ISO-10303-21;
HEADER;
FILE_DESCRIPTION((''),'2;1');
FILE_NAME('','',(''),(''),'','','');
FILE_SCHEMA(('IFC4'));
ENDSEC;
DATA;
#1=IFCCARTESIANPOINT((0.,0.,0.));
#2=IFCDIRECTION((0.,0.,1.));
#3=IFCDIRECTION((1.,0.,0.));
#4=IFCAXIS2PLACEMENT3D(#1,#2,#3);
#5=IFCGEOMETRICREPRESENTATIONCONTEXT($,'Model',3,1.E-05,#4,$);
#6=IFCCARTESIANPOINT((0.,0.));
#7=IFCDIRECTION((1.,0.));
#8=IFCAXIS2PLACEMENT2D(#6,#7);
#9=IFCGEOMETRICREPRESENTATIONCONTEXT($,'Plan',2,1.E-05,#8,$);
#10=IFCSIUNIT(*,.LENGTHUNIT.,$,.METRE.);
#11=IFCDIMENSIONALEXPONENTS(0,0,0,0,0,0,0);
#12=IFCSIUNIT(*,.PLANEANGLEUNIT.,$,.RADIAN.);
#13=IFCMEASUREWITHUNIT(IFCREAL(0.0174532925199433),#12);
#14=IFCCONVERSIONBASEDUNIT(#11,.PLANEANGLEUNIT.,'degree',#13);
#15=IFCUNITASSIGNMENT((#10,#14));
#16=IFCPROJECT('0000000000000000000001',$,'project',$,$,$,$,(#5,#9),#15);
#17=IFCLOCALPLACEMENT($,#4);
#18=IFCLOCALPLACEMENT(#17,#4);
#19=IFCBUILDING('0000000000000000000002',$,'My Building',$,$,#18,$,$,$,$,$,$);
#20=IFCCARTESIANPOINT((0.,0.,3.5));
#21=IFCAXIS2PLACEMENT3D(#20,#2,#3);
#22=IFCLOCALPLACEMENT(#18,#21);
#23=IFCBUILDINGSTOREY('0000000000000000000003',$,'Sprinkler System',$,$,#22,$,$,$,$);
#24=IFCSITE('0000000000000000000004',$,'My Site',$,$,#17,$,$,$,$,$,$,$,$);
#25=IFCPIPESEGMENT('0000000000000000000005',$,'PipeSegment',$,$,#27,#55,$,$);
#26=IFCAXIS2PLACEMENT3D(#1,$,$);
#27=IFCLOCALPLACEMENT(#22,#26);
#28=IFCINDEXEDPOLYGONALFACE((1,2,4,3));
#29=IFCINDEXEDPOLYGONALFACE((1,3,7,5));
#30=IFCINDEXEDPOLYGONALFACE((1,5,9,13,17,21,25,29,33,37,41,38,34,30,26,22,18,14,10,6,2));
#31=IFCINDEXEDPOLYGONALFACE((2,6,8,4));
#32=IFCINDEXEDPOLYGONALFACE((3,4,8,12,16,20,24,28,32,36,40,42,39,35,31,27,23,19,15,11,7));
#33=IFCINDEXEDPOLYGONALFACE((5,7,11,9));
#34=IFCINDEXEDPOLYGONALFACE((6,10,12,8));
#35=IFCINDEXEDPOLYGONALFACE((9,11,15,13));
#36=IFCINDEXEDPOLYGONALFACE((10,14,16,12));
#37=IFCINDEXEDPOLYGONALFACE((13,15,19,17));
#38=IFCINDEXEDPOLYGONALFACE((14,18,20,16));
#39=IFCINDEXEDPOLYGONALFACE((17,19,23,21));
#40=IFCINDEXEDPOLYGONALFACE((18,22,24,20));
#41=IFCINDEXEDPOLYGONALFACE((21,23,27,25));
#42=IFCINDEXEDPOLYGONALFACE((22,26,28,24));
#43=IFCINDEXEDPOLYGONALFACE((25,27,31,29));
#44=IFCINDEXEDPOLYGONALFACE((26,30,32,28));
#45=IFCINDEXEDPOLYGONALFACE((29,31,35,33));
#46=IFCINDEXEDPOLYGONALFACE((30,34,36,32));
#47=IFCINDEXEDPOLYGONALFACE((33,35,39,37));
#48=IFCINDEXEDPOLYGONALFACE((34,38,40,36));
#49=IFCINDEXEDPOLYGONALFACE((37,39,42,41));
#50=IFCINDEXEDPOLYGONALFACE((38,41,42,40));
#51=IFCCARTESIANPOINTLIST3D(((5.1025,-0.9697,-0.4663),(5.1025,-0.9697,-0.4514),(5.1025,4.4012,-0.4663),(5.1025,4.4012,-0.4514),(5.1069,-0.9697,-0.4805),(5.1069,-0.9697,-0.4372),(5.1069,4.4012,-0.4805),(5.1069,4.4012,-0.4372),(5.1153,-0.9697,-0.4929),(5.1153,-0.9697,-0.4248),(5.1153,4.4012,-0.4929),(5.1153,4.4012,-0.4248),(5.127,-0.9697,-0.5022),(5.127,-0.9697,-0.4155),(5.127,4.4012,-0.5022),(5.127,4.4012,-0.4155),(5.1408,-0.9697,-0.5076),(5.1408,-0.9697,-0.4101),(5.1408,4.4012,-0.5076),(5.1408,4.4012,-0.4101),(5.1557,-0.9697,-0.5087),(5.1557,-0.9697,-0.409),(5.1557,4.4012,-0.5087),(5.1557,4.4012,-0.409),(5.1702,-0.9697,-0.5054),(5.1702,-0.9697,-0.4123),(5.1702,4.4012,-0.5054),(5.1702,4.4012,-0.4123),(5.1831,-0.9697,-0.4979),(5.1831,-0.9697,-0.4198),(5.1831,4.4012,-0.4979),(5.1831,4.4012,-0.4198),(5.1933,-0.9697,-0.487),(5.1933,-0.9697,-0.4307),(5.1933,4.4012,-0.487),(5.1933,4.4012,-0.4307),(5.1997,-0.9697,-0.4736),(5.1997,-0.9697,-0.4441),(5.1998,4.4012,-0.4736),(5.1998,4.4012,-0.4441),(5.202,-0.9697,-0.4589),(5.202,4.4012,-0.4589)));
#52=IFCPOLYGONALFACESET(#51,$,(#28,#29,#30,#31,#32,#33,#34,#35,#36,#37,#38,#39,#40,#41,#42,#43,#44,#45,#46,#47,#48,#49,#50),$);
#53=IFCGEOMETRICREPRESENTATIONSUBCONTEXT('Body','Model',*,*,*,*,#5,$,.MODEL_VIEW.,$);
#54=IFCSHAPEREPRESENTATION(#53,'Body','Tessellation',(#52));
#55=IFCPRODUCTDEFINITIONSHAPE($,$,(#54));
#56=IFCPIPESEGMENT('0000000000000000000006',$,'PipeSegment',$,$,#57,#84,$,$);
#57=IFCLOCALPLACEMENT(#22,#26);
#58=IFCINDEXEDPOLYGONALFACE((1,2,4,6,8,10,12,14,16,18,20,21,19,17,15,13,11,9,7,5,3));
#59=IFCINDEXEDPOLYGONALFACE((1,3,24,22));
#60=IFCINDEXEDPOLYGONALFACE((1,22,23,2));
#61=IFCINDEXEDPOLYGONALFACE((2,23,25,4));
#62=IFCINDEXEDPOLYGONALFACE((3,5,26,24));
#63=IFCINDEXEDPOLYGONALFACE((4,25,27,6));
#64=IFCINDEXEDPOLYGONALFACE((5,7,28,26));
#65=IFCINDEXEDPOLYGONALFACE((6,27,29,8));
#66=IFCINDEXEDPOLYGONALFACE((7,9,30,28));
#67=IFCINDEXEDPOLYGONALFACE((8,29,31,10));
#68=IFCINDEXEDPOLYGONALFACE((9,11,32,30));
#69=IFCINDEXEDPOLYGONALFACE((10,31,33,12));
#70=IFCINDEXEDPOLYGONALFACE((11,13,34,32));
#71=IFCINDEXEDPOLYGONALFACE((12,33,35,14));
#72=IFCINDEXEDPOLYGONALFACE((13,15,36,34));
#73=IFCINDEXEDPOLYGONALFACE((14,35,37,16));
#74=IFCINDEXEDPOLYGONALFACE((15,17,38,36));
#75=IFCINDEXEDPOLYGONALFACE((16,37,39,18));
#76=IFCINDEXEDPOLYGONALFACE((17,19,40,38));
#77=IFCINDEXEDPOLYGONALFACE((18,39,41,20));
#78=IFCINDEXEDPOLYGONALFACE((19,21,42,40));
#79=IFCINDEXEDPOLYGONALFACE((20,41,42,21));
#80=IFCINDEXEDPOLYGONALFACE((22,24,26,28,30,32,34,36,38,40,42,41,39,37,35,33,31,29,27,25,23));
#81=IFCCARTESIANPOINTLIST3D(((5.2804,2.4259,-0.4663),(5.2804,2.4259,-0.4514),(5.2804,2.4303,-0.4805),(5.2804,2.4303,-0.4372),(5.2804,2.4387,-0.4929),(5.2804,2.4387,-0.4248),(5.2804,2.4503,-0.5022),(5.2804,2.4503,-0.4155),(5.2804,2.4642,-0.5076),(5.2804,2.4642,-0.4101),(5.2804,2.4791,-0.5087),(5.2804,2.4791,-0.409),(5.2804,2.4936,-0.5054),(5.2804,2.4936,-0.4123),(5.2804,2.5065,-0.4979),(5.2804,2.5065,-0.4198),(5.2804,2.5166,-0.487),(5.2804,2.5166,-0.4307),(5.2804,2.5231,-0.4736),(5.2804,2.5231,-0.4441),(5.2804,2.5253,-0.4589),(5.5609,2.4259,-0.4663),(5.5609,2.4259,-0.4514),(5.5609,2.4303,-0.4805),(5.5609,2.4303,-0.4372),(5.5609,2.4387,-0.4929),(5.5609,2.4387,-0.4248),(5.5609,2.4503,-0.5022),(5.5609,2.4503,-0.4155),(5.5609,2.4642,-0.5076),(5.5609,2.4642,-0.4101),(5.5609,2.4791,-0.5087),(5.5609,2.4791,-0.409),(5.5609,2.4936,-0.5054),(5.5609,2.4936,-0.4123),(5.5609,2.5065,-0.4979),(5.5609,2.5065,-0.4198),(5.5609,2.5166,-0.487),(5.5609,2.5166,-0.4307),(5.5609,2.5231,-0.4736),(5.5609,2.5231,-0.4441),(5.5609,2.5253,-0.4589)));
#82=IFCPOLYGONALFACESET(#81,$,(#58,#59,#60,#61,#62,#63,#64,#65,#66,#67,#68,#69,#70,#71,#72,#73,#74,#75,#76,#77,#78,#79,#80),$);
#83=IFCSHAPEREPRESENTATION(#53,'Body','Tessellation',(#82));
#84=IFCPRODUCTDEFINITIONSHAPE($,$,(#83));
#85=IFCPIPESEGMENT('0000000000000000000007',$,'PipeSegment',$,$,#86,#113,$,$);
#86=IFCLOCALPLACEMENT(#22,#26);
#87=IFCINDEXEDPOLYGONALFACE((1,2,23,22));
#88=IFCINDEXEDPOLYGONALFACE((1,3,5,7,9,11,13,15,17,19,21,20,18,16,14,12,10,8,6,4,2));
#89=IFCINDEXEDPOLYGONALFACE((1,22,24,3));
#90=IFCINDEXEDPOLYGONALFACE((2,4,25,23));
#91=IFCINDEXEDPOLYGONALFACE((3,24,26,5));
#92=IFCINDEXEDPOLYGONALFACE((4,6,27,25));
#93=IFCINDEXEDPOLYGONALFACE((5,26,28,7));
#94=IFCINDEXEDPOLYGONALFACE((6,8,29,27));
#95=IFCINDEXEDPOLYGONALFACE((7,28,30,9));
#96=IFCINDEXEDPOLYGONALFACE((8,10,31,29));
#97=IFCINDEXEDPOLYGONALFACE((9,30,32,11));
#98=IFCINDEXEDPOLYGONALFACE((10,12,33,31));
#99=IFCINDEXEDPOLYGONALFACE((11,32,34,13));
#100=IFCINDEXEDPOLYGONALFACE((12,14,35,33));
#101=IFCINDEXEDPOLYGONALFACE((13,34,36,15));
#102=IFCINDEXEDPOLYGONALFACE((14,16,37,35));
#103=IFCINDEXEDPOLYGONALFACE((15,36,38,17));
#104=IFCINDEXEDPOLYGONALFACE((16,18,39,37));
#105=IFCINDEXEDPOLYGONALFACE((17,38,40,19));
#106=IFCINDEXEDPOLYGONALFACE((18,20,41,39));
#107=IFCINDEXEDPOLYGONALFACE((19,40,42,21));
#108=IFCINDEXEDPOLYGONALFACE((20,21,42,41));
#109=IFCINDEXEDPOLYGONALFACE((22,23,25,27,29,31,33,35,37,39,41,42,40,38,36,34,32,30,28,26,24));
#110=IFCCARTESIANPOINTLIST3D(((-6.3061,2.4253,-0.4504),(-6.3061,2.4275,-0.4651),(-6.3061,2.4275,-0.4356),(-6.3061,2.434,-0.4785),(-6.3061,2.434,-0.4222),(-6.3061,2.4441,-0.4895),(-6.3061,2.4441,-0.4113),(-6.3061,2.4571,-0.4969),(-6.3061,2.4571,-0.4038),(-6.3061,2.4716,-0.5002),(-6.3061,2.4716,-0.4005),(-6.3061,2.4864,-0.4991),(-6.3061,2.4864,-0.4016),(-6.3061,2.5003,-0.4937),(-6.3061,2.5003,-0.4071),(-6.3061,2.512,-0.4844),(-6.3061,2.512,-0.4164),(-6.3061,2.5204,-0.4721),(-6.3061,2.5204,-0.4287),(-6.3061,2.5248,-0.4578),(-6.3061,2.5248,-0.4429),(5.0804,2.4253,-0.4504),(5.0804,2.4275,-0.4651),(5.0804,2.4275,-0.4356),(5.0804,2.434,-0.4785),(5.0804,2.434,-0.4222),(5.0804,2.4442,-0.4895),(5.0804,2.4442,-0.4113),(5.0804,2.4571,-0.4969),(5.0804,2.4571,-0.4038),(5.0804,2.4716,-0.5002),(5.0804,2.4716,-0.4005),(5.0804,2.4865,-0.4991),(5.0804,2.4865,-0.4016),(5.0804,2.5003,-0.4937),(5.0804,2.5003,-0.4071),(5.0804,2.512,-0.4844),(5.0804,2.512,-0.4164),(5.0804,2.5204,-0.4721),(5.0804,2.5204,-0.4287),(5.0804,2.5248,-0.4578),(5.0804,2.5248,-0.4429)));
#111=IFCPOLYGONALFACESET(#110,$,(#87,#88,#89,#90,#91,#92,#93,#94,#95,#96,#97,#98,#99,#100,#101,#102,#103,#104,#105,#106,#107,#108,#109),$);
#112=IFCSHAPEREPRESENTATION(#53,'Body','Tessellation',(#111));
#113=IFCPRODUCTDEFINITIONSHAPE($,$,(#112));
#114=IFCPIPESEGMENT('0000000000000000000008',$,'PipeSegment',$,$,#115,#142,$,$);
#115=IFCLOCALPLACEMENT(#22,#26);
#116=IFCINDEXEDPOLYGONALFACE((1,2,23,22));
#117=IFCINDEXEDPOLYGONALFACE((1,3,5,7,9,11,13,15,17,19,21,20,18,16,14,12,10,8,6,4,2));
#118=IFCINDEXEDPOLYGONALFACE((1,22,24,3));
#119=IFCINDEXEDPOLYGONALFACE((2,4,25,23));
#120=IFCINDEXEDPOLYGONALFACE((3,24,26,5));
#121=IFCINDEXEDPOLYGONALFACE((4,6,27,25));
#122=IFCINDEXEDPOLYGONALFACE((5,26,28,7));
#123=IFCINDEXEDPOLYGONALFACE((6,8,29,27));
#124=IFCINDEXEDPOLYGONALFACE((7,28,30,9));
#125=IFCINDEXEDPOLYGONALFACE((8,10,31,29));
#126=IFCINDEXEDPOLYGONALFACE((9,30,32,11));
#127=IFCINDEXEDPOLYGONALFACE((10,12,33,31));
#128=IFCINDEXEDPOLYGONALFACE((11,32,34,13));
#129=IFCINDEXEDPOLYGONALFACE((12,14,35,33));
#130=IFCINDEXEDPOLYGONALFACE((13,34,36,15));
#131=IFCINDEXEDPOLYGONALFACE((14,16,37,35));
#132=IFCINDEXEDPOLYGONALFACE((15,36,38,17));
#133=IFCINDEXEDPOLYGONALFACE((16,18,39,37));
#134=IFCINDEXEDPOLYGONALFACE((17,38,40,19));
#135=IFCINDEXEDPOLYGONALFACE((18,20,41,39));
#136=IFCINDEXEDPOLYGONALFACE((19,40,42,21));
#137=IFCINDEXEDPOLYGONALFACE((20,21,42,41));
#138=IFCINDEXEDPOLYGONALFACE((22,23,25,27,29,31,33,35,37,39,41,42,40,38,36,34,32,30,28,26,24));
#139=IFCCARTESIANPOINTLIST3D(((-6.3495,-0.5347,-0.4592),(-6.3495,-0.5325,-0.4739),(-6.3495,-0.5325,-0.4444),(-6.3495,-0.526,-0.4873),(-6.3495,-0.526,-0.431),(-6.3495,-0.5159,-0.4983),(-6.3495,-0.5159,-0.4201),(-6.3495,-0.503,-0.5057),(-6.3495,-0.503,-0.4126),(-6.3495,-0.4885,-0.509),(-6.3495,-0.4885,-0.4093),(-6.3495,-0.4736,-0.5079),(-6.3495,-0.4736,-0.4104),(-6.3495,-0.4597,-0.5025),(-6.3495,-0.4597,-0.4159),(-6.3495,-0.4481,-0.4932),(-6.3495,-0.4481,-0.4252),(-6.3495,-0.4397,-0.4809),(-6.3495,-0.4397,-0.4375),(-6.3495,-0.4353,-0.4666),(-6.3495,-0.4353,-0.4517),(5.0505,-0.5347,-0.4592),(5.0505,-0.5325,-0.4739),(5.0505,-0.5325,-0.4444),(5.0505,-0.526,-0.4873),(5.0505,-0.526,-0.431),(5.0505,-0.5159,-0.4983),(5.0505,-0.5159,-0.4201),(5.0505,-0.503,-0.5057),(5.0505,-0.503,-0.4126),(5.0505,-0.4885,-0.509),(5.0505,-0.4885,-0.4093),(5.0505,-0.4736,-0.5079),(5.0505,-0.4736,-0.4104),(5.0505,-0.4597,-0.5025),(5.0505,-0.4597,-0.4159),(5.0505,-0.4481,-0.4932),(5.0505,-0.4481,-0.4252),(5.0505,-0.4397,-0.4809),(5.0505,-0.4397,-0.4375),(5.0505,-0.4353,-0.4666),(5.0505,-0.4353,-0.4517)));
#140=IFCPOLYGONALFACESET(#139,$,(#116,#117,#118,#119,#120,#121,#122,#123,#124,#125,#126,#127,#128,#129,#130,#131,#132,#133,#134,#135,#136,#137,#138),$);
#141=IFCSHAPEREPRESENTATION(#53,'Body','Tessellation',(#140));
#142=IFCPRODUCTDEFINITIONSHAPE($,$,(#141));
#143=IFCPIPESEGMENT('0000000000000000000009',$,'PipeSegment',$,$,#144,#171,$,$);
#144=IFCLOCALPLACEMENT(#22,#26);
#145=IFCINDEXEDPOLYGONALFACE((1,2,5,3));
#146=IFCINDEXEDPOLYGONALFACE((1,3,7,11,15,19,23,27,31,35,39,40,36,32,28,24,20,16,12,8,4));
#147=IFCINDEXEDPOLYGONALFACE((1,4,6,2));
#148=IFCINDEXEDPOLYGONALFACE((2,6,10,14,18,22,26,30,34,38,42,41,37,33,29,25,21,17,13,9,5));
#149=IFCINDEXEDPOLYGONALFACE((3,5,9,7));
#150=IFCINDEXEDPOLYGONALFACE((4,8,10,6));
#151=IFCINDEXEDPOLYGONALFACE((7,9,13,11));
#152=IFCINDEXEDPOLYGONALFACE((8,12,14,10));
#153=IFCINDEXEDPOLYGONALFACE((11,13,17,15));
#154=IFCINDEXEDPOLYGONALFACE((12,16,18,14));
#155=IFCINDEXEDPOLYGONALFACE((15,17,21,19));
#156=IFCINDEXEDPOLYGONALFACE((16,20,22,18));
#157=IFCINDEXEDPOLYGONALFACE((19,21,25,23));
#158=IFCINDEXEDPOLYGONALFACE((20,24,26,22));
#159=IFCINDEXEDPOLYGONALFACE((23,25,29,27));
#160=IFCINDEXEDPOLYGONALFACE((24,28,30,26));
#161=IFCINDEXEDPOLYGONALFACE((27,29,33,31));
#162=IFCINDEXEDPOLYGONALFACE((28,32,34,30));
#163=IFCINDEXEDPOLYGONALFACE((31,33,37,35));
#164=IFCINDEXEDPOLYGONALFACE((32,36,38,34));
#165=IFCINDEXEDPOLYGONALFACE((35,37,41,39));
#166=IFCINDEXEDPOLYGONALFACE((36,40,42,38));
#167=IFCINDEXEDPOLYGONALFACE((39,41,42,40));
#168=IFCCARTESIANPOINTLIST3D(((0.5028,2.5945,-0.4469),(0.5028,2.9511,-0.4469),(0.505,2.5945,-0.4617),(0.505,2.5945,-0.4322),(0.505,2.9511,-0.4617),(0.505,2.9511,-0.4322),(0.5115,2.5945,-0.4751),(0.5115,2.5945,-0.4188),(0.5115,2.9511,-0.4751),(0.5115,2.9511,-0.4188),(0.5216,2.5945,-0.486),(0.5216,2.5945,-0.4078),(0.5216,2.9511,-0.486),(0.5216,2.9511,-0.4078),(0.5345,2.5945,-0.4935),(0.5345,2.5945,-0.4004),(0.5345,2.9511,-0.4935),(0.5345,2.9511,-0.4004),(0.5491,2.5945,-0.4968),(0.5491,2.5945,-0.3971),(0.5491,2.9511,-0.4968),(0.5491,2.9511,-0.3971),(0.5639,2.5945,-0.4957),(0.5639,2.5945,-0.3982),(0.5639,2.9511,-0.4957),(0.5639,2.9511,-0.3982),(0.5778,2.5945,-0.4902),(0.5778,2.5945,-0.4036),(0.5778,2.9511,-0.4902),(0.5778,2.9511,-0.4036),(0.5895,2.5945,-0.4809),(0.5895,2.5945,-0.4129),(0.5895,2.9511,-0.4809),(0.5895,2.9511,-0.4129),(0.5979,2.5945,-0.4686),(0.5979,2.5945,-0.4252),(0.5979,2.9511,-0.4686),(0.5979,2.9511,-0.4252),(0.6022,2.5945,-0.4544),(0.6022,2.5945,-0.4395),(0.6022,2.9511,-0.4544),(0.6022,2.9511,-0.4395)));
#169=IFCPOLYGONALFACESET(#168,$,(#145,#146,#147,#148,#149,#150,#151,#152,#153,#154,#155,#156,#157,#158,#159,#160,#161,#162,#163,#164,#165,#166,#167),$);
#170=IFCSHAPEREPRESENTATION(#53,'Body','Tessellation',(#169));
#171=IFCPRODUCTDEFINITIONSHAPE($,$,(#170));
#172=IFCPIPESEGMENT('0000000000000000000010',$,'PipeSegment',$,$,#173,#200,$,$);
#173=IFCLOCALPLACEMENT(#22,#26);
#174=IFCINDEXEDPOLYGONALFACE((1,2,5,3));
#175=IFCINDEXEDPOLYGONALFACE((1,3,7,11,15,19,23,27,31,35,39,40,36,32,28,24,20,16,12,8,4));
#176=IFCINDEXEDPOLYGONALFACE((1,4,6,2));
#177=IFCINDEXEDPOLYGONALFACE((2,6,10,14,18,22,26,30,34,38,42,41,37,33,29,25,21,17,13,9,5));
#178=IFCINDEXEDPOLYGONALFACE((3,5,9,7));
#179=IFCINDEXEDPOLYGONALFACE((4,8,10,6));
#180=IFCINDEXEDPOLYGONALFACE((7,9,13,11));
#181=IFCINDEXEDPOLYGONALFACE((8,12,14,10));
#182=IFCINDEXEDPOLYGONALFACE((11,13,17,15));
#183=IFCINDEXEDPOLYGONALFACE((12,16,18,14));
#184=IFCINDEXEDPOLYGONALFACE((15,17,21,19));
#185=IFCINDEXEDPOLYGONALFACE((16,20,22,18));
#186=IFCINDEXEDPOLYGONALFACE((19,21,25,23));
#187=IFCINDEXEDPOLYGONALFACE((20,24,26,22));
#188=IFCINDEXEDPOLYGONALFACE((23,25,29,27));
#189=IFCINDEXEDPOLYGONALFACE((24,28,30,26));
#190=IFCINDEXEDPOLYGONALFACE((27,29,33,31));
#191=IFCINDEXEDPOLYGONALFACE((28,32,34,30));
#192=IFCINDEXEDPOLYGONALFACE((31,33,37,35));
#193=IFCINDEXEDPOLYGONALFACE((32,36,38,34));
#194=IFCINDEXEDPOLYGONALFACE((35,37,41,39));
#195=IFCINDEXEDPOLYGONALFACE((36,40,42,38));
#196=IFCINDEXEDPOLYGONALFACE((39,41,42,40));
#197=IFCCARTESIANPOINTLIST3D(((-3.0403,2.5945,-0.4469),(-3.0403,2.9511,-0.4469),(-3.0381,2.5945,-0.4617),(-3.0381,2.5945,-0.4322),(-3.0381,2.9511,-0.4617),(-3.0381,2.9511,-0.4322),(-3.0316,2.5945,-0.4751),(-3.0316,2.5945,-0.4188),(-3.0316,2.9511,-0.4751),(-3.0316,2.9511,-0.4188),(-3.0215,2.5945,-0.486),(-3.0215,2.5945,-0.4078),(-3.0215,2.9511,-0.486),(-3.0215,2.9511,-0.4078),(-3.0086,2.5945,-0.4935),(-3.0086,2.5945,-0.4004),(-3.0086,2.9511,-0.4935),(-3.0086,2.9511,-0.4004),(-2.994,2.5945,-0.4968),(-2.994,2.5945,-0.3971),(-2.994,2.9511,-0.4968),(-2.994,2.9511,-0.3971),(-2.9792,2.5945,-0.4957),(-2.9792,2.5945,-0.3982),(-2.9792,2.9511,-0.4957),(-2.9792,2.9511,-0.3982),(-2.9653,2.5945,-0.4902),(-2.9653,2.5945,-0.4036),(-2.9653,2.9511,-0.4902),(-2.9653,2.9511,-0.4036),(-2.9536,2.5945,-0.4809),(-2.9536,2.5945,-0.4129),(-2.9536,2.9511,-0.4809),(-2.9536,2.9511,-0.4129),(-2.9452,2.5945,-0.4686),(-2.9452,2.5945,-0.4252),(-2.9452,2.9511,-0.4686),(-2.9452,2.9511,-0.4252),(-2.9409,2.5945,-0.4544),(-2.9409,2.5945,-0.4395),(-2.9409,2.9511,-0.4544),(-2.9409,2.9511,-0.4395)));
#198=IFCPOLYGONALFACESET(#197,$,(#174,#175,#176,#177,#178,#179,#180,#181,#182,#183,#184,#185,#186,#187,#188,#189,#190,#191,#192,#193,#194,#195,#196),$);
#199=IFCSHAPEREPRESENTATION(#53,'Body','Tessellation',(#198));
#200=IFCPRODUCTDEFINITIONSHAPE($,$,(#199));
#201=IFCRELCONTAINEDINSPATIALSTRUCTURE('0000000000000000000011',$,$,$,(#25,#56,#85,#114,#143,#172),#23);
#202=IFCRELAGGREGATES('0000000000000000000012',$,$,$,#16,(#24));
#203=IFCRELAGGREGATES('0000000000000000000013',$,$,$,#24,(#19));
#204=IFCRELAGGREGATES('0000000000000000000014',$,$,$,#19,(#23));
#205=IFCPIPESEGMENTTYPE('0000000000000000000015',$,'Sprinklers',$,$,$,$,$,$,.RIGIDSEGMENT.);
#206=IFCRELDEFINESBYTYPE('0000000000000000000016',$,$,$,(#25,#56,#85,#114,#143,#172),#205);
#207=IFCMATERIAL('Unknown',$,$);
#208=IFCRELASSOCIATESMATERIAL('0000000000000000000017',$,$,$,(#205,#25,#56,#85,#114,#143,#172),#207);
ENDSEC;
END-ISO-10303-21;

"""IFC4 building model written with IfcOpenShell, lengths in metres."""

from ifc_helpers import new_model, entity, si_unit, converted_unit, frame, origin_with_axes, origin_2d_with_axis, place, context, subcontext, project, spatial, circle, extrude, material, material_profile, profile_set, profile_usage, type_object, element, save


model = new_model("IFC4")

# Units and contexts
model_context = context("Model", 3, precision=1e-05, world=origin_with_axes())
plan_context = context("Plan", 2, precision=1e-05, world=origin_2d_with_axis())
body_context = subcontext(model_context, "Body", "Model", "MODEL_VIEW")
ifc_project = project(units=[si_unit("LENGTHUNIT", "METRE"), converted_unit("PLANEANGLEUNIT", "degree", entity("IfcReal", 0.0174532925199433), si_unit("PLANEANGLEUNIT", "RADIAN"), dimensions=[0, 0, 0, 0, 0, 0, 0])], contexts=[model_context, plan_context])

# Site, building, storey
site_placement = place(None, origin_with_axes())
site = spatial("IfcSite", under=ifc_project, at=site_placement, Name="My Site")
building_placement = place(site_placement, origin_with_axes())
building = spatial("IfcBuilding", under=site, at=building_placement, Name="My Building")
storey_placement = place(building_placement, frame((0.0, 0.0, 3.5), z_axis=(0.0, 0.0, 1.0), x_axis=(1.0, 0.0, 0.0)))
storey = spatial("IfcBuildingStorey", under=building, at=storey_placement, Name="Sprinkler System")

# Pipe segments
ifc_material = material(Name="Unknown")
ifc_material_profile_1 = material_profile(ifc_material, circle(Radius=0.05))
ifc_profile_set_1 = profile_set([ifc_material_profile_1])
ifc_profile_usage_1 = profile_usage(ifc_profile_set_1, cardinal=5)
pipe_segment_type = type_object("IfcPipeSegmentType", Name="Sprinklers", PredefinedType="RIGIDSEGMENT", material=ifc_profile_set_1)
pipe_segment_1_placement = place(storey_placement, frame((5.152, 4.4012, -0.4589), z_axis=(0.0, -1.0, 0.0), x_axis=(1.0, 0.0, 0.0)))
element("IfcPipeSegment", 1, at=pipe_segment_1_placement, inside=storey, type_object=pipe_segment_type, material=ifc_profile_usage_1, Name="PipeSegment", context=body_context, shape_type="SweptSolid", body=[
    extrude(circle(Radius=0.05), origin_with_axes(), (0.0, 0.0, 1.0), 5.3709),
])
ifc_profile_usage_2 = profile_usage(ifc_profile_set_1, cardinal=5)
pipe_segment_2_placement = place(storey_placement, frame((5.2804, 2.4753, -0.4589), z_axis=(1.0, 0.0, 0.0), x_axis=(0.0, 1.0, 0.0)))
element("IfcPipeSegment", 2, at=pipe_segment_2_placement, inside=storey, type_object=pipe_segment_type, material=ifc_profile_usage_2, Name="PipeSegment", context=body_context, shape_type="SweptSolid", body=[
    extrude(circle(Radius=0.05), origin_with_axes(), (0.0, 0.0, 1.0), 0.2805),
])
ifc_profile_usage_3 = profile_usage(ifc_profile_set_1, cardinal=5)
pipe_segment_3_placement = place(storey_placement, frame((5.0804, 2.4753, -0.4504), z_axis=(-1.0, -0.000001, 0.0), x_axis=(0.000001, -1.0, 0.0)))
element("IfcPipeSegment", 3, at=pipe_segment_3_placement, inside=storey, type_object=pipe_segment_type, material=ifc_profile_usage_3, Name="PipeSegment", context=body_context, shape_type="SweptSolid", body=[
    extrude(circle(Radius=0.05), origin_with_axes(), (0.0, 0.0, 1.0), 11.3865),
])
ifc_profile_usage_4 = profile_usage(ifc_profile_set_1, cardinal=5)
pipe_segment_4_placement = place(storey_placement, frame((5.0505, -0.4847, -0.4592), z_axis=(-1.0, 0.0, 0.0), x_axis=(0.0, -1.0, 0.0)))
element("IfcPipeSegment", 4, at=pipe_segment_4_placement, inside=storey, type_object=pipe_segment_type, material=ifc_profile_usage_4, Name="PipeSegment", context=body_context, shape_type="SweptSolid", body=[
    extrude(circle(Radius=0.05), origin_with_axes(), (0.0, 0.0, 1.0), 11.4),
])
ifc_profile_usage_5 = profile_usage(ifc_profile_set_1, cardinal=5)
pipe_segment_5_placement = place(storey_placement, frame((0.5528, 2.5945, -0.4469), z_axis=(0.0, 1.0, -0.00001), x_axis=(-1.0, 0.0, 0.0)))
element("IfcPipeSegment", 5, at=pipe_segment_5_placement, inside=storey, type_object=pipe_segment_type, material=ifc_profile_usage_5, Name="PipeSegment", context=body_context, shape_type="SweptSolid", body=[
    extrude(circle(Radius=0.05), origin_with_axes(), (0.0, 0.0, 1.0), 0.3566),
])
ifc_profile_usage_6 = profile_usage(ifc_profile_set_1, cardinal=5)
pipe_segment_6_placement = place(storey_placement, frame((-2.9903, 2.5945, -0.4469), z_axis=(0.0, 1.0, -0.00001), x_axis=(-1.0, 0.0, 0.0)))
element("IfcPipeSegment", 6, at=pipe_segment_6_placement, inside=storey, type_object=pipe_segment_type, material=ifc_profile_usage_6, Name="PipeSegment", context=body_context, shape_type="SweptSolid", body=[
    extrude(circle(Radius=0.05), origin_with_axes(), (0.0, 0.0, 1.0), 0.3566),
])

save(model, "model.ifc")
